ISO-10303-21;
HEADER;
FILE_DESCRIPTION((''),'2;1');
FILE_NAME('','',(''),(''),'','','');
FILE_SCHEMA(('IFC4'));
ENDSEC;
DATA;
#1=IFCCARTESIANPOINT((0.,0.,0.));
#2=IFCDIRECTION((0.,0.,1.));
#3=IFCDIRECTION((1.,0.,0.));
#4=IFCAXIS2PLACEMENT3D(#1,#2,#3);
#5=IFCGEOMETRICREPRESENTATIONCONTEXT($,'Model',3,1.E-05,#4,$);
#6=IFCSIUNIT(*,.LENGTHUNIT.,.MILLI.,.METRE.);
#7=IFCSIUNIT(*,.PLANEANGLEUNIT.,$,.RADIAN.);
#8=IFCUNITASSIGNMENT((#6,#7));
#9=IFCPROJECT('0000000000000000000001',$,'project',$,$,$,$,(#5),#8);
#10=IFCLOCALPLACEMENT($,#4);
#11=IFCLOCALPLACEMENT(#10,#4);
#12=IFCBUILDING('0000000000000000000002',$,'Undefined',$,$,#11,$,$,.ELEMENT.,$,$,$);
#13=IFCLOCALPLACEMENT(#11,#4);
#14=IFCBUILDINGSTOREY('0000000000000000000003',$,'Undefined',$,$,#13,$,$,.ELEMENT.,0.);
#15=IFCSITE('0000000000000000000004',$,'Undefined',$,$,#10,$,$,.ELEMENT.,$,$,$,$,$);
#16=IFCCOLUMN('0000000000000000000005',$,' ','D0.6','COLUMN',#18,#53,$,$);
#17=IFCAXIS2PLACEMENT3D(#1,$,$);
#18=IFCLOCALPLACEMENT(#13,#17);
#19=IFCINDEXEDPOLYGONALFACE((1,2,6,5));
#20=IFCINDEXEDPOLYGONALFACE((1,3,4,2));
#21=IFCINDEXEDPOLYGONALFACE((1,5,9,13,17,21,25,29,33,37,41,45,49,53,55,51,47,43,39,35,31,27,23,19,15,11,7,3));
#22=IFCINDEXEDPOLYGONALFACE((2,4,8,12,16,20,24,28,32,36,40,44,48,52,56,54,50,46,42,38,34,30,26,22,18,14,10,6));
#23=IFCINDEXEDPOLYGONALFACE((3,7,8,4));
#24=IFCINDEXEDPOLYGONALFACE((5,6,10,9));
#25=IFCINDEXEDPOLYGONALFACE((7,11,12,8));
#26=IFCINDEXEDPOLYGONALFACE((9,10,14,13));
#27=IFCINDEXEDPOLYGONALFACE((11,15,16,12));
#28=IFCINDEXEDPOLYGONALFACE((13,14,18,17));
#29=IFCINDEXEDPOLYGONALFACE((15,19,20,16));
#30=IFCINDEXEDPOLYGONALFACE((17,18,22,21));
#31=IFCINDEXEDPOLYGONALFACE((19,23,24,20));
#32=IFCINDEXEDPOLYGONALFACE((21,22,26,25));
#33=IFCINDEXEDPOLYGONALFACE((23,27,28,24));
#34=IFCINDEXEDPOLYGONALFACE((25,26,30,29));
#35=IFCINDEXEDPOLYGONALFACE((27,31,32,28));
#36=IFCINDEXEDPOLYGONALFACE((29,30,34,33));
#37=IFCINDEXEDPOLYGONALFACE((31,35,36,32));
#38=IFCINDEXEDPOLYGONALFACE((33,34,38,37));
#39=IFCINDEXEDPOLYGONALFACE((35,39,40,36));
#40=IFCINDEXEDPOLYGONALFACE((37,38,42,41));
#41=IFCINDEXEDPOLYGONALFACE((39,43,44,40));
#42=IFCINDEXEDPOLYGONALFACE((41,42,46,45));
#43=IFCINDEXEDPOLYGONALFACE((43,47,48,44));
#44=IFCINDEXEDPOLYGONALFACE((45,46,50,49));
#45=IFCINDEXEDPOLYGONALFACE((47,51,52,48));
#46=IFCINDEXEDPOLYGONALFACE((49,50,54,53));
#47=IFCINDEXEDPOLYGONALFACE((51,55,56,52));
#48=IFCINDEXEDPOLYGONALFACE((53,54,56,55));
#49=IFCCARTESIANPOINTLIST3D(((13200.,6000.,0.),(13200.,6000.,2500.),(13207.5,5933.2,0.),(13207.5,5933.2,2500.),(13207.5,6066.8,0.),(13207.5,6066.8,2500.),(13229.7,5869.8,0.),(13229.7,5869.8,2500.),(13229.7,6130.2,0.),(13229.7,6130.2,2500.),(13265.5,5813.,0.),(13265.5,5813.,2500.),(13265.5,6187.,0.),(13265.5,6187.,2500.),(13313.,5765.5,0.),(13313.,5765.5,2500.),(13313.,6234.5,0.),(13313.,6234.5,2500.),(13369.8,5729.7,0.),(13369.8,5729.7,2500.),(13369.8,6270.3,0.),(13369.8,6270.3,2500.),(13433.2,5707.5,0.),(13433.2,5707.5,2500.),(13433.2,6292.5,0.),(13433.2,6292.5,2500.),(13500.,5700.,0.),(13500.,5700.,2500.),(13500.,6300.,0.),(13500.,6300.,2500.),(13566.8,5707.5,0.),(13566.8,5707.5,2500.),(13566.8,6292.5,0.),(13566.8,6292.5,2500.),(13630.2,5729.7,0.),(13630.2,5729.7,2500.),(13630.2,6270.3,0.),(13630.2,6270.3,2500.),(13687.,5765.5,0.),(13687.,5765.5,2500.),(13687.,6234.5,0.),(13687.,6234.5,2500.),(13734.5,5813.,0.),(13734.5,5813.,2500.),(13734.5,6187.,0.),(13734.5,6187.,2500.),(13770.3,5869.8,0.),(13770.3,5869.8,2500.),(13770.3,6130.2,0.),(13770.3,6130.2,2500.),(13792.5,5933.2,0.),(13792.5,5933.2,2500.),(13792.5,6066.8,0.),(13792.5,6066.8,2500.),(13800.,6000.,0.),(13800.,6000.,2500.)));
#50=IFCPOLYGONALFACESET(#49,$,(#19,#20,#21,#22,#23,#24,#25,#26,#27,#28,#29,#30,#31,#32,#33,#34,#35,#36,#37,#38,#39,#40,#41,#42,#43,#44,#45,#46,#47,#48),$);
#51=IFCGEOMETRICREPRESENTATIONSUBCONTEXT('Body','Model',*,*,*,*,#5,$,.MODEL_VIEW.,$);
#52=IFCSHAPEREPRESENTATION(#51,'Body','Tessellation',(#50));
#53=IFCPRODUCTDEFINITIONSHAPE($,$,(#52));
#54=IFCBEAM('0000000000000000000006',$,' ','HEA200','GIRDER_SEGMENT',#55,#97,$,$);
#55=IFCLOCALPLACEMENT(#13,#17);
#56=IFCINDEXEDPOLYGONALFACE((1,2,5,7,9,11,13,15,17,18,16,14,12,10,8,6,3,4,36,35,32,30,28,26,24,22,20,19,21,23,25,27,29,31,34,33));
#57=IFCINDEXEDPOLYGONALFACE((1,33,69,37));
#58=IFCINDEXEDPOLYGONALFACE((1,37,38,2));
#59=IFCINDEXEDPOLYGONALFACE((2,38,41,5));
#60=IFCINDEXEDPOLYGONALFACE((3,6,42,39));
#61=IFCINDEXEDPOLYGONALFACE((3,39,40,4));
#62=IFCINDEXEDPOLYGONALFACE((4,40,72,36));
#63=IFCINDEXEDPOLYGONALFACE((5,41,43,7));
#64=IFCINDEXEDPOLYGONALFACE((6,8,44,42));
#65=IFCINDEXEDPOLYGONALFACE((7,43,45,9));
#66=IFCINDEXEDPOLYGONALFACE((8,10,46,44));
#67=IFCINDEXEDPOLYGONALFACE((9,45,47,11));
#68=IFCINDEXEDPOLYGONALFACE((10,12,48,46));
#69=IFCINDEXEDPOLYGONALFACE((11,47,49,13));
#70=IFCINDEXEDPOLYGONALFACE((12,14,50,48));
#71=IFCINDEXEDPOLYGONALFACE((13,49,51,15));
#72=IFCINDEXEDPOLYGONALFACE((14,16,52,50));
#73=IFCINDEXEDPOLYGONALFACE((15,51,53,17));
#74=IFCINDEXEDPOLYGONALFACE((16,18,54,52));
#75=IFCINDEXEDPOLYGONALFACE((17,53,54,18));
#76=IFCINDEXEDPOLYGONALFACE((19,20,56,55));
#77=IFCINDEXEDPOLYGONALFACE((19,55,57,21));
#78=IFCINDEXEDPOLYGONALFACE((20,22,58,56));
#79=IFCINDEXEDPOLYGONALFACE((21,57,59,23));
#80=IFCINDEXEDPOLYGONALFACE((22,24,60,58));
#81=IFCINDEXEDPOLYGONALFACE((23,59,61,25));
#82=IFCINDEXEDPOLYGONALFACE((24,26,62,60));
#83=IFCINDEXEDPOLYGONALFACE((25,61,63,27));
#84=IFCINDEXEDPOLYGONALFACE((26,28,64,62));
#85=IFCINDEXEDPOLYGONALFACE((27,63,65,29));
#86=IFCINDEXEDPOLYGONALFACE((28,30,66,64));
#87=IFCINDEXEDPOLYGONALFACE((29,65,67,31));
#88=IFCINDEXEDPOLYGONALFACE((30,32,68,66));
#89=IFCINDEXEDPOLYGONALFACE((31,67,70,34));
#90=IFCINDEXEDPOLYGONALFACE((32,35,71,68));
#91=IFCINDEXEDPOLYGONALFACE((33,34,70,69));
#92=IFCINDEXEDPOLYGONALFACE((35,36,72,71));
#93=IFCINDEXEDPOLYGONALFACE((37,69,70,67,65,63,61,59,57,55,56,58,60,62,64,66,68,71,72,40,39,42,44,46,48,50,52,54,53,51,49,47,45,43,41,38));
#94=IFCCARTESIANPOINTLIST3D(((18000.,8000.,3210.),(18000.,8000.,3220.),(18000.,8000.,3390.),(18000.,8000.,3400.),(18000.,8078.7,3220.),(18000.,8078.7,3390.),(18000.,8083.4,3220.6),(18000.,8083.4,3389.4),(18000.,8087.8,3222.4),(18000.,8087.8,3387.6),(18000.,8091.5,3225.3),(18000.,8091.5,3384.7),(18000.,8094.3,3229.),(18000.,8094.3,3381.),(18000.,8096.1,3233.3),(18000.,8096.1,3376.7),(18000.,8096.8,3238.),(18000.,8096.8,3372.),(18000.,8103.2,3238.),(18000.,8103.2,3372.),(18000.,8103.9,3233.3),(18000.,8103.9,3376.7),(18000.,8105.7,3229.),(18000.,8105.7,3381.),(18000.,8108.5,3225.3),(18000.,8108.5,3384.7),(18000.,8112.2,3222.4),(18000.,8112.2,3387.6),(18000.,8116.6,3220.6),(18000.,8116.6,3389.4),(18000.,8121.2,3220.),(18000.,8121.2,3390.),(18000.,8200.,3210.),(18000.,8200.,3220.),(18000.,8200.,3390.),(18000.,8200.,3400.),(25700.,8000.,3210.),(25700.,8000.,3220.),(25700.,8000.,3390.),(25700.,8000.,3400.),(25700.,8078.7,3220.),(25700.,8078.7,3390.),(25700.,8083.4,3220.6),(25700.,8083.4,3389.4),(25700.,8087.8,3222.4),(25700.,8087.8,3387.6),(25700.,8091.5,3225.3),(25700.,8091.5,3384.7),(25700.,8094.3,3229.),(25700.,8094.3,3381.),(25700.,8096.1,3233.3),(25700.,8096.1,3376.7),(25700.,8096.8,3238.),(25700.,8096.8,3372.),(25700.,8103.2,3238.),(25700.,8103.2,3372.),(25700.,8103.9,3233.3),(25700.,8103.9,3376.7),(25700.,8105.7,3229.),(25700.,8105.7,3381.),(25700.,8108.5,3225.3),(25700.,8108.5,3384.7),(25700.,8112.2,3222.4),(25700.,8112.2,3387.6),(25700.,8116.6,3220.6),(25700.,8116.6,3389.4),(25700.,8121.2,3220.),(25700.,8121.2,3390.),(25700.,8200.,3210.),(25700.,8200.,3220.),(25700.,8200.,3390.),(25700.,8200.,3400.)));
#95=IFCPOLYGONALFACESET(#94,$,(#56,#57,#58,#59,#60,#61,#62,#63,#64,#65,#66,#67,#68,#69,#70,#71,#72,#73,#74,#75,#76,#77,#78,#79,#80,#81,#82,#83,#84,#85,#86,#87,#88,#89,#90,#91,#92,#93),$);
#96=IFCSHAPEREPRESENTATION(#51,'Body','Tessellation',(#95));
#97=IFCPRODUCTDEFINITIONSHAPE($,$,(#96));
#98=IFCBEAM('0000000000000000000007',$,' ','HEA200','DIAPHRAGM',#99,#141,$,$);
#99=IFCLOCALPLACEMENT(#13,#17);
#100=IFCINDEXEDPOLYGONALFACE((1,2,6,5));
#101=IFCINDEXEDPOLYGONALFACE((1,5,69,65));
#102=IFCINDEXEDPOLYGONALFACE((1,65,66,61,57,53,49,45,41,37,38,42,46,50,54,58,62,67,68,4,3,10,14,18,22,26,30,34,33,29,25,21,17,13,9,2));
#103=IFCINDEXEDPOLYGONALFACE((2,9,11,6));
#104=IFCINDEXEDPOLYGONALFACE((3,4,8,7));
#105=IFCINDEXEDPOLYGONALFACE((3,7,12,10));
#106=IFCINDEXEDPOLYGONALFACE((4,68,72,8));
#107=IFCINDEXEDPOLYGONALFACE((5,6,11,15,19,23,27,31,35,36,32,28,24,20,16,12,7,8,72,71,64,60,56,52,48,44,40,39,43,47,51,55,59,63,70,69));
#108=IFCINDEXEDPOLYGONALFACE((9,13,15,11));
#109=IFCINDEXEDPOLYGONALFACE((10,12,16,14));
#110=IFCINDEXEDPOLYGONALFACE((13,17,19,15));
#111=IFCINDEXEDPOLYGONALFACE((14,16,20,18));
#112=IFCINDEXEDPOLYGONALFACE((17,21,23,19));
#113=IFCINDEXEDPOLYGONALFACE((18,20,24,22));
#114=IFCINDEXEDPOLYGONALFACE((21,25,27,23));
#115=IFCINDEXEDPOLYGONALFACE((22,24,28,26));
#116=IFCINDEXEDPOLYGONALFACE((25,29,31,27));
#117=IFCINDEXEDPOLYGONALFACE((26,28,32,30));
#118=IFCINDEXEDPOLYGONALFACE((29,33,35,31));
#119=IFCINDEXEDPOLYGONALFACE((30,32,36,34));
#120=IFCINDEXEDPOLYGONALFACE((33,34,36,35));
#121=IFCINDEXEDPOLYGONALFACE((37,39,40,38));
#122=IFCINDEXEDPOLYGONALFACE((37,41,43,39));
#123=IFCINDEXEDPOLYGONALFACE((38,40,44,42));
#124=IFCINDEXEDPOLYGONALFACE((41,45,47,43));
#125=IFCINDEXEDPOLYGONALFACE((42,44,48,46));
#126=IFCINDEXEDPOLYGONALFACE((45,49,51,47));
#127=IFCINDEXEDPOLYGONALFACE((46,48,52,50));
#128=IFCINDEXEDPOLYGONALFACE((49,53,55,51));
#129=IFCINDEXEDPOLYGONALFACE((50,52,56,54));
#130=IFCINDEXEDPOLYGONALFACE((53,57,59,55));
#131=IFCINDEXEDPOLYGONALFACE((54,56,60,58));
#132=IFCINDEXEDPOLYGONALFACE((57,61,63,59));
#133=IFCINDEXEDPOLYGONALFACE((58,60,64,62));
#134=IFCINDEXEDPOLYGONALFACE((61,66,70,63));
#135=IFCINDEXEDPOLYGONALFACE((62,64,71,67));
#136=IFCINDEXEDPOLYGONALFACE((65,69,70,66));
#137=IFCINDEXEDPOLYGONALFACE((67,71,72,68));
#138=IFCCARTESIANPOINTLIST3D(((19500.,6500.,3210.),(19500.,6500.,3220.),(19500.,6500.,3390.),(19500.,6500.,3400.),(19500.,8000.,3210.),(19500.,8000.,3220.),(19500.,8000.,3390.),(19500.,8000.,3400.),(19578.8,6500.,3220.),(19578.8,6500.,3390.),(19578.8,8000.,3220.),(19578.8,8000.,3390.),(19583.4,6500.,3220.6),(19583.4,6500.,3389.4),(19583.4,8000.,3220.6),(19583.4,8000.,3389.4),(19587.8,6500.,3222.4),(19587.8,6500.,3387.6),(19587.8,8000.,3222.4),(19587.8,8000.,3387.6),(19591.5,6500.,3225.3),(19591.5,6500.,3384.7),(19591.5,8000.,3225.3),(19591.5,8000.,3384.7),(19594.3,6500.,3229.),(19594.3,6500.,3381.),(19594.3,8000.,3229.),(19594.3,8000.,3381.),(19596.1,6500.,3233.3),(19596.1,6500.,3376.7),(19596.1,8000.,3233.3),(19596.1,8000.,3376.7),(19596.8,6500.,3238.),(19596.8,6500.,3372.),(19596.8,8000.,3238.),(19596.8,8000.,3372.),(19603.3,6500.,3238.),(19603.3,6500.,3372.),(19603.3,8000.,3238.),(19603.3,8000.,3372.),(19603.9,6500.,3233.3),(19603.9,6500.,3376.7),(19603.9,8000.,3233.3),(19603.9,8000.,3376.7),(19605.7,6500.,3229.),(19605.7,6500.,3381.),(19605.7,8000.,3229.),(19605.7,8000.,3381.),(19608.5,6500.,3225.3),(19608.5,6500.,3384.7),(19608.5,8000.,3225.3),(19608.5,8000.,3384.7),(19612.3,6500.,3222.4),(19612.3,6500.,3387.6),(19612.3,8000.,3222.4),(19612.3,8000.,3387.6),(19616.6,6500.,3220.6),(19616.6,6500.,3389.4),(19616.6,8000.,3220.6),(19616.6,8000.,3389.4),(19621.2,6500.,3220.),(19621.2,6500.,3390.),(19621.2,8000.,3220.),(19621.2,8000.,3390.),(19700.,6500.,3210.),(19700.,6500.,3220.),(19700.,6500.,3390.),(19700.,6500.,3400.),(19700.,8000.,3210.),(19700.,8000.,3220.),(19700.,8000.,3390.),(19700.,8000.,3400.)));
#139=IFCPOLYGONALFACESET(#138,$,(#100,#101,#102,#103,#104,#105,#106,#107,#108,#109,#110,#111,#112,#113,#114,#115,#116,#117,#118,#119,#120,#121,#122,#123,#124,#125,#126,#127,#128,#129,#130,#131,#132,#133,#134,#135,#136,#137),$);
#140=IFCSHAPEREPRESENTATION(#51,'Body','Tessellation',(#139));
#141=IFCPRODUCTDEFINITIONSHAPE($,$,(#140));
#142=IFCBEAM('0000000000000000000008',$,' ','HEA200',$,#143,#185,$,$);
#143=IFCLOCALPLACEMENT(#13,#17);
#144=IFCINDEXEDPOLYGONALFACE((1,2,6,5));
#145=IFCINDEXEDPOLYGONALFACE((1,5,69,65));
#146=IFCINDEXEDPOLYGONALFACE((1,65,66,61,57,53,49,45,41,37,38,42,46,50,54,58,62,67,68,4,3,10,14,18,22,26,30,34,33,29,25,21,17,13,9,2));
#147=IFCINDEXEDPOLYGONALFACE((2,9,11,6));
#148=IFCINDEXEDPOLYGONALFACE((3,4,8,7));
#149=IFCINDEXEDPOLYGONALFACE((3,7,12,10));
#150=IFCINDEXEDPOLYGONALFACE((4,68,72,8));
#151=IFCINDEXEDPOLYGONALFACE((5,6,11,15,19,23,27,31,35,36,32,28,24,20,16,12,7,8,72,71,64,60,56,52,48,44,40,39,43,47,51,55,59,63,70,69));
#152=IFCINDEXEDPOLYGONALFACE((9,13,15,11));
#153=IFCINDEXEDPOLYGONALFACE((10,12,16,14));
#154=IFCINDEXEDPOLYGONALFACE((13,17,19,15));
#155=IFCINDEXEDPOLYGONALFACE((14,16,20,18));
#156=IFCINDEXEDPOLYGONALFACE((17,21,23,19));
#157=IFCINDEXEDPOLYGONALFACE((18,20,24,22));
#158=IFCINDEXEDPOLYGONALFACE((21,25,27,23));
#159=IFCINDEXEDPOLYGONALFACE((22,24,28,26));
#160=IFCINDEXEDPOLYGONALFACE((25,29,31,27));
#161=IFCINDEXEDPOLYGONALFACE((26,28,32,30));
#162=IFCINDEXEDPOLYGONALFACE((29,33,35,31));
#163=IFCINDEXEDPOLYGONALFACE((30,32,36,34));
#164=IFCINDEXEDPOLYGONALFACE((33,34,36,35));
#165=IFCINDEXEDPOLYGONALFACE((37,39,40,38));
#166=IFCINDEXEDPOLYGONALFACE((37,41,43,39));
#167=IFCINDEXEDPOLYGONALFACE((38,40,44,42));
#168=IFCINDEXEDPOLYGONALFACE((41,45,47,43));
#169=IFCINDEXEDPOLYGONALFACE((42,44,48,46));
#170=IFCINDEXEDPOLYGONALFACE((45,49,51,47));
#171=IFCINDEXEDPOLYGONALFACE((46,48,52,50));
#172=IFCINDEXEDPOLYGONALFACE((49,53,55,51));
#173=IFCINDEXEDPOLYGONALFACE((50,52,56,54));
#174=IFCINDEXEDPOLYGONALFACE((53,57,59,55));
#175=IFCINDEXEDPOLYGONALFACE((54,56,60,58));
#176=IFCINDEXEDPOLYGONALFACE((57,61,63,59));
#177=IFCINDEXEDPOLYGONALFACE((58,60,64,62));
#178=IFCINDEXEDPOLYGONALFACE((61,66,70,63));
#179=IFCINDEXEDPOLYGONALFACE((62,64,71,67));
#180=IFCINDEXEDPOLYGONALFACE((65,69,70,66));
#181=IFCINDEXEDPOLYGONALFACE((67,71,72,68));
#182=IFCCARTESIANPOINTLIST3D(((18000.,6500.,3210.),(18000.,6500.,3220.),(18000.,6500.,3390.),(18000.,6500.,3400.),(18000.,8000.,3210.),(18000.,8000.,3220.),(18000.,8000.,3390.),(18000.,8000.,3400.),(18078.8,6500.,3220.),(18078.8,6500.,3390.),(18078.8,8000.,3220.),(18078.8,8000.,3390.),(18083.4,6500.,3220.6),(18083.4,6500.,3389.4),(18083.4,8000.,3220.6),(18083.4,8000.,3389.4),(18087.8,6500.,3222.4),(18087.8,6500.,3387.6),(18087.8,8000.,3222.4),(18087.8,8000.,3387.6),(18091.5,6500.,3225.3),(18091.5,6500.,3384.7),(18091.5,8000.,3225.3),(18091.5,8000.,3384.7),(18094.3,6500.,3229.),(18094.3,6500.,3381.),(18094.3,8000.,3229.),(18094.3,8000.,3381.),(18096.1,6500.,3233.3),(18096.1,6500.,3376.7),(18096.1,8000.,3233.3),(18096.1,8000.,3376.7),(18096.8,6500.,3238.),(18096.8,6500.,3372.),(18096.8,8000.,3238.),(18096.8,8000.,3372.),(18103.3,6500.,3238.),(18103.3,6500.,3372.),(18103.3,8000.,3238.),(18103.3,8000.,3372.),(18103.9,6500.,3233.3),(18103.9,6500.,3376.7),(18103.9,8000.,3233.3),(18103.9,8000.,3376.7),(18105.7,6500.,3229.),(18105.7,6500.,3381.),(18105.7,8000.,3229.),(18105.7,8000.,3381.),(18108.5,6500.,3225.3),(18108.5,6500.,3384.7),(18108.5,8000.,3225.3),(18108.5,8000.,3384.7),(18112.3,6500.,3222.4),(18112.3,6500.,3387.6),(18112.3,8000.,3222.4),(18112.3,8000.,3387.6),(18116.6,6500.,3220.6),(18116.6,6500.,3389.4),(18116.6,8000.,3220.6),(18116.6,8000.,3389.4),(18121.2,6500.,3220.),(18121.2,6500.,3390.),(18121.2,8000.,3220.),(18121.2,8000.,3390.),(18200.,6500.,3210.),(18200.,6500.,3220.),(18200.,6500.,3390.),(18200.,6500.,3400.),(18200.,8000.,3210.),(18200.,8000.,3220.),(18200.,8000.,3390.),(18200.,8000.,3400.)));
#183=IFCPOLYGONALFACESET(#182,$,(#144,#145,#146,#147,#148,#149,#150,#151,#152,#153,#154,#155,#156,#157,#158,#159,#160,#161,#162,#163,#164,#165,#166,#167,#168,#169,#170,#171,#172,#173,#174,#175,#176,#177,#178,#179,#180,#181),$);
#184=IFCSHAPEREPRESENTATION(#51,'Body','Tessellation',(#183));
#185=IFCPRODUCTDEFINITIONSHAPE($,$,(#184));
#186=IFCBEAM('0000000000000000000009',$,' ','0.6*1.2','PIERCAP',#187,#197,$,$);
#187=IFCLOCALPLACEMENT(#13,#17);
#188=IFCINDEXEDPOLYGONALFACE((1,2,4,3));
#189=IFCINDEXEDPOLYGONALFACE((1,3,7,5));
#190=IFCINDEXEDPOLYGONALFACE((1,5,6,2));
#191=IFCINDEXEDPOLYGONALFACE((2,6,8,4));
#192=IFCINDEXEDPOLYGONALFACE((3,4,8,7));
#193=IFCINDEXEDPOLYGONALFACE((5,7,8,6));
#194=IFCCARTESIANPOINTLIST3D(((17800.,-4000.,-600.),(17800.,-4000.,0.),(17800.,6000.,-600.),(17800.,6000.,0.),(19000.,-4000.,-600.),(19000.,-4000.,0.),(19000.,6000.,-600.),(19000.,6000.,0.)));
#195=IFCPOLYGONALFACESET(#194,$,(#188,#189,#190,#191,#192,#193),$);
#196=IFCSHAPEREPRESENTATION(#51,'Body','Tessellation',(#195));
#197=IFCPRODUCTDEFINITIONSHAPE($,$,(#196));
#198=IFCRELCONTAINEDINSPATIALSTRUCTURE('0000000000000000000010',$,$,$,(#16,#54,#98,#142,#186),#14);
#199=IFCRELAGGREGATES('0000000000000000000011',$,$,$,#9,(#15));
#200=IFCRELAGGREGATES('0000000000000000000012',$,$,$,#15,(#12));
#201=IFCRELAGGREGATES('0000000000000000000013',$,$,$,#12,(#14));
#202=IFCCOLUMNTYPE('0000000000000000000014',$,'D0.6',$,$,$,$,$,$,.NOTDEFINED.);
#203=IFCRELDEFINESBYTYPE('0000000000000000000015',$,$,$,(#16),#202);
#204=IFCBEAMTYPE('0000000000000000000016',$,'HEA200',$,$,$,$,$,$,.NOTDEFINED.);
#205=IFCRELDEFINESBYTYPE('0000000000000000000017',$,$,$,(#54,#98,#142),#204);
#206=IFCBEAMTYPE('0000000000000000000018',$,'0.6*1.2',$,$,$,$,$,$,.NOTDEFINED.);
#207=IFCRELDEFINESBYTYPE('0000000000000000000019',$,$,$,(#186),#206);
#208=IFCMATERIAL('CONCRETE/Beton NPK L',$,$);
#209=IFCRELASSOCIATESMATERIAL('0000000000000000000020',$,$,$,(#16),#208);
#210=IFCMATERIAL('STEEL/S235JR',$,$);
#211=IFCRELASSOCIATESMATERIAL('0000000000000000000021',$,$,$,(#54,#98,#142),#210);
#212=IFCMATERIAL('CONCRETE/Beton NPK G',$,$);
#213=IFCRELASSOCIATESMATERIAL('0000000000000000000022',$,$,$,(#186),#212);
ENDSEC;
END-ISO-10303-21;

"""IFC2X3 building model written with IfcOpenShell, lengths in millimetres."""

from ifc_helpers import new_model, si_unit, frame, origin_with_axes, origin_2d_with_axis, place, context, subcontext, project, spatial, rectangle, circle, i_section, extrude, material, type_object, element, save


model = new_model("IFC2X3")

# Units and contexts
model_context = context("Model", 3, precision=1e-05, world=origin_with_axes())
body_context = subcontext(model_context, "Body", "Model", "MODEL_VIEW")
ifc_project = project(units=[si_unit("LENGTHUNIT", "METRE", prefix="MILLI"), si_unit("PLANEANGLEUNIT", "RADIAN")], contexts=[model_context])

# Site, building, storey
site_placement = place(None, origin_with_axes())
site = spatial("IfcSite", under=ifc_project, at=site_placement, Name="Undefined", CompositionType="ELEMENT")
building_placement = place(site_placement, origin_with_axes())
building = spatial("IfcBuilding", under=site, at=building_placement, Name="Undefined", CompositionType="ELEMENT")
storey_placement = place(building_placement, origin_with_axes())
storey = spatial("IfcBuildingStorey", under=building, at=storey_placement, Name="Undefined", CompositionType="ELEMENT", Elevation=0.0)

# Shared definitions
ifc_material_1 = material(Name="CONCRETE/Beton NPK L")

# Column
column_type = type_object("IfcColumnType", Name="D0.6", PredefinedType="NOTDEFINED")
column_placement = place(storey_placement, frame((13500.0, 6000.0, 0.0), z_axis=(0.0, 0.0, 1.0), x_axis=(0.0, 1.0, 0.0)))
element("IfcColumn", 1, at=column_placement, inside=storey, type_object=column_type, material=ifc_material_1, Name=" ", Description="D0.6", ObjectType="COLUMN", context=body_context, shape_type="SweptSolid", body=[
    extrude(circle(Radius=300.0, at=origin_2d_with_axis()), frame((0.0, 0.0, 2500.0), z_axis=(0.0, 0.0, -1.0), x_axis=(0.0, 1.0, 0.0)), (0.0, 0.0, 1.0), 2500.0),
])

# Beams
ifc_material_2 = material(Name="STEEL/S235JR")
beam_type_1 = type_object("IfcBeamType", Name="HEA200", PredefinedType="NOTDEFINED")
beam_1_placement = place(storey_placement, frame((18000.0, 8100.0, 3305.0), z_axis=(0.0, 0.0, 1.0), x_axis=(1.0, 0.0, 0.0)))
element("IfcBeam", 2, at=beam_1_placement, inside=storey, type_object=beam_type_1, material=ifc_material_2, Name=" ", Description="HEA200", ObjectType="GIRDER_SEGMENT", context=body_context, shape_type="SweptSolid", body=[
    extrude(i_section(OverallWidth=200.0, OverallDepth=190.0, WebThickness=6.5, FlangeThickness=10.0, FilletRadius=18.0, at=origin_2d_with_axis()), frame((7700.0, 0.0, 0.0), z_axis=(-1.0, 0.0, 0.0), x_axis=(0.0, -1.0, 0.0)), (0.0, 0.0, 1.0), 7700.0),
])
beam_2_placement = place(storey_placement, frame((19600.0, 6500.0, 3305.0), z_axis=(0.0, 0.0, 1.0), x_axis=(0.0, 1.0, 0.0)))
element("IfcBeam", 3, at=beam_2_placement, inside=storey, type_object=beam_type_1, material=ifc_material_2, Name=" ", Description="HEA200", ObjectType="DIAPHRAGM", context=body_context, shape_type="SweptSolid", body=[
    extrude(i_section(OverallWidth=200.0, OverallDepth=190.0, WebThickness=6.5, FlangeThickness=10.0, FilletRadius=18.0, at=origin_2d_with_axis()), frame((1500.0, 0.0, 0.0), z_axis=(-1.0, 0.0, 0.0), x_axis=(0.0, -1.0, 0.0)), (0.0, 0.0, 1.0), 1500.0),
])
beam_3_placement = place(storey_placement, frame((18100.0, 6500.0, 3305.0), z_axis=(0.0, 0.0, 1.0), x_axis=(0.0, 1.0, 0.0)))
element("IfcBeam", 4, at=beam_3_placement, inside=storey, type_object=beam_type_1, material=ifc_material_2, Name=" ", Description="HEA200", context=body_context, shape_type="SweptSolid", body=[
    extrude(i_section(OverallWidth=200.0, OverallDepth=190.0, WebThickness=6.5, FlangeThickness=10.0, FilletRadius=18.0, at=origin_2d_with_axis()), frame((1500.0, 0.0, 0.0), z_axis=(-1.0, 0.0, 0.0), x_axis=(0.0, -1.0, 0.0)), (0.0, 0.0, 1.0), 1500.0),
])
ifc_material_3 = material(Name="CONCRETE/Beton NPK G")
beam_type_2 = type_object("IfcBeamType", Name="0.6*1.2", PredefinedType="NOTDEFINED")
beam_4_placement = place(storey_placement, frame((18400.0, 6000.0, -300.0), z_axis=(0.0, 0.0, 1.0), x_axis=(0.0, -1.0, 0.0)))
element("IfcBeam", 5, at=beam_4_placement, inside=storey, type_object=beam_type_2, material=ifc_material_3, Name=" ", Description="0.6*1.2", ObjectType="PIERCAP", context=body_context, shape_type="SweptSolid", body=[
    extrude(rectangle(XDim=1200.0, YDim=600.0, at=origin_2d_with_axis()), frame((10000.0, 0.0, 0.0), z_axis=(-1.0, 0.0, 0.0), x_axis=(0.0, -1.0, 0.0)), (0.0, 0.0, 1.0), 10000.0),
])

save(model, "model.ifc")
